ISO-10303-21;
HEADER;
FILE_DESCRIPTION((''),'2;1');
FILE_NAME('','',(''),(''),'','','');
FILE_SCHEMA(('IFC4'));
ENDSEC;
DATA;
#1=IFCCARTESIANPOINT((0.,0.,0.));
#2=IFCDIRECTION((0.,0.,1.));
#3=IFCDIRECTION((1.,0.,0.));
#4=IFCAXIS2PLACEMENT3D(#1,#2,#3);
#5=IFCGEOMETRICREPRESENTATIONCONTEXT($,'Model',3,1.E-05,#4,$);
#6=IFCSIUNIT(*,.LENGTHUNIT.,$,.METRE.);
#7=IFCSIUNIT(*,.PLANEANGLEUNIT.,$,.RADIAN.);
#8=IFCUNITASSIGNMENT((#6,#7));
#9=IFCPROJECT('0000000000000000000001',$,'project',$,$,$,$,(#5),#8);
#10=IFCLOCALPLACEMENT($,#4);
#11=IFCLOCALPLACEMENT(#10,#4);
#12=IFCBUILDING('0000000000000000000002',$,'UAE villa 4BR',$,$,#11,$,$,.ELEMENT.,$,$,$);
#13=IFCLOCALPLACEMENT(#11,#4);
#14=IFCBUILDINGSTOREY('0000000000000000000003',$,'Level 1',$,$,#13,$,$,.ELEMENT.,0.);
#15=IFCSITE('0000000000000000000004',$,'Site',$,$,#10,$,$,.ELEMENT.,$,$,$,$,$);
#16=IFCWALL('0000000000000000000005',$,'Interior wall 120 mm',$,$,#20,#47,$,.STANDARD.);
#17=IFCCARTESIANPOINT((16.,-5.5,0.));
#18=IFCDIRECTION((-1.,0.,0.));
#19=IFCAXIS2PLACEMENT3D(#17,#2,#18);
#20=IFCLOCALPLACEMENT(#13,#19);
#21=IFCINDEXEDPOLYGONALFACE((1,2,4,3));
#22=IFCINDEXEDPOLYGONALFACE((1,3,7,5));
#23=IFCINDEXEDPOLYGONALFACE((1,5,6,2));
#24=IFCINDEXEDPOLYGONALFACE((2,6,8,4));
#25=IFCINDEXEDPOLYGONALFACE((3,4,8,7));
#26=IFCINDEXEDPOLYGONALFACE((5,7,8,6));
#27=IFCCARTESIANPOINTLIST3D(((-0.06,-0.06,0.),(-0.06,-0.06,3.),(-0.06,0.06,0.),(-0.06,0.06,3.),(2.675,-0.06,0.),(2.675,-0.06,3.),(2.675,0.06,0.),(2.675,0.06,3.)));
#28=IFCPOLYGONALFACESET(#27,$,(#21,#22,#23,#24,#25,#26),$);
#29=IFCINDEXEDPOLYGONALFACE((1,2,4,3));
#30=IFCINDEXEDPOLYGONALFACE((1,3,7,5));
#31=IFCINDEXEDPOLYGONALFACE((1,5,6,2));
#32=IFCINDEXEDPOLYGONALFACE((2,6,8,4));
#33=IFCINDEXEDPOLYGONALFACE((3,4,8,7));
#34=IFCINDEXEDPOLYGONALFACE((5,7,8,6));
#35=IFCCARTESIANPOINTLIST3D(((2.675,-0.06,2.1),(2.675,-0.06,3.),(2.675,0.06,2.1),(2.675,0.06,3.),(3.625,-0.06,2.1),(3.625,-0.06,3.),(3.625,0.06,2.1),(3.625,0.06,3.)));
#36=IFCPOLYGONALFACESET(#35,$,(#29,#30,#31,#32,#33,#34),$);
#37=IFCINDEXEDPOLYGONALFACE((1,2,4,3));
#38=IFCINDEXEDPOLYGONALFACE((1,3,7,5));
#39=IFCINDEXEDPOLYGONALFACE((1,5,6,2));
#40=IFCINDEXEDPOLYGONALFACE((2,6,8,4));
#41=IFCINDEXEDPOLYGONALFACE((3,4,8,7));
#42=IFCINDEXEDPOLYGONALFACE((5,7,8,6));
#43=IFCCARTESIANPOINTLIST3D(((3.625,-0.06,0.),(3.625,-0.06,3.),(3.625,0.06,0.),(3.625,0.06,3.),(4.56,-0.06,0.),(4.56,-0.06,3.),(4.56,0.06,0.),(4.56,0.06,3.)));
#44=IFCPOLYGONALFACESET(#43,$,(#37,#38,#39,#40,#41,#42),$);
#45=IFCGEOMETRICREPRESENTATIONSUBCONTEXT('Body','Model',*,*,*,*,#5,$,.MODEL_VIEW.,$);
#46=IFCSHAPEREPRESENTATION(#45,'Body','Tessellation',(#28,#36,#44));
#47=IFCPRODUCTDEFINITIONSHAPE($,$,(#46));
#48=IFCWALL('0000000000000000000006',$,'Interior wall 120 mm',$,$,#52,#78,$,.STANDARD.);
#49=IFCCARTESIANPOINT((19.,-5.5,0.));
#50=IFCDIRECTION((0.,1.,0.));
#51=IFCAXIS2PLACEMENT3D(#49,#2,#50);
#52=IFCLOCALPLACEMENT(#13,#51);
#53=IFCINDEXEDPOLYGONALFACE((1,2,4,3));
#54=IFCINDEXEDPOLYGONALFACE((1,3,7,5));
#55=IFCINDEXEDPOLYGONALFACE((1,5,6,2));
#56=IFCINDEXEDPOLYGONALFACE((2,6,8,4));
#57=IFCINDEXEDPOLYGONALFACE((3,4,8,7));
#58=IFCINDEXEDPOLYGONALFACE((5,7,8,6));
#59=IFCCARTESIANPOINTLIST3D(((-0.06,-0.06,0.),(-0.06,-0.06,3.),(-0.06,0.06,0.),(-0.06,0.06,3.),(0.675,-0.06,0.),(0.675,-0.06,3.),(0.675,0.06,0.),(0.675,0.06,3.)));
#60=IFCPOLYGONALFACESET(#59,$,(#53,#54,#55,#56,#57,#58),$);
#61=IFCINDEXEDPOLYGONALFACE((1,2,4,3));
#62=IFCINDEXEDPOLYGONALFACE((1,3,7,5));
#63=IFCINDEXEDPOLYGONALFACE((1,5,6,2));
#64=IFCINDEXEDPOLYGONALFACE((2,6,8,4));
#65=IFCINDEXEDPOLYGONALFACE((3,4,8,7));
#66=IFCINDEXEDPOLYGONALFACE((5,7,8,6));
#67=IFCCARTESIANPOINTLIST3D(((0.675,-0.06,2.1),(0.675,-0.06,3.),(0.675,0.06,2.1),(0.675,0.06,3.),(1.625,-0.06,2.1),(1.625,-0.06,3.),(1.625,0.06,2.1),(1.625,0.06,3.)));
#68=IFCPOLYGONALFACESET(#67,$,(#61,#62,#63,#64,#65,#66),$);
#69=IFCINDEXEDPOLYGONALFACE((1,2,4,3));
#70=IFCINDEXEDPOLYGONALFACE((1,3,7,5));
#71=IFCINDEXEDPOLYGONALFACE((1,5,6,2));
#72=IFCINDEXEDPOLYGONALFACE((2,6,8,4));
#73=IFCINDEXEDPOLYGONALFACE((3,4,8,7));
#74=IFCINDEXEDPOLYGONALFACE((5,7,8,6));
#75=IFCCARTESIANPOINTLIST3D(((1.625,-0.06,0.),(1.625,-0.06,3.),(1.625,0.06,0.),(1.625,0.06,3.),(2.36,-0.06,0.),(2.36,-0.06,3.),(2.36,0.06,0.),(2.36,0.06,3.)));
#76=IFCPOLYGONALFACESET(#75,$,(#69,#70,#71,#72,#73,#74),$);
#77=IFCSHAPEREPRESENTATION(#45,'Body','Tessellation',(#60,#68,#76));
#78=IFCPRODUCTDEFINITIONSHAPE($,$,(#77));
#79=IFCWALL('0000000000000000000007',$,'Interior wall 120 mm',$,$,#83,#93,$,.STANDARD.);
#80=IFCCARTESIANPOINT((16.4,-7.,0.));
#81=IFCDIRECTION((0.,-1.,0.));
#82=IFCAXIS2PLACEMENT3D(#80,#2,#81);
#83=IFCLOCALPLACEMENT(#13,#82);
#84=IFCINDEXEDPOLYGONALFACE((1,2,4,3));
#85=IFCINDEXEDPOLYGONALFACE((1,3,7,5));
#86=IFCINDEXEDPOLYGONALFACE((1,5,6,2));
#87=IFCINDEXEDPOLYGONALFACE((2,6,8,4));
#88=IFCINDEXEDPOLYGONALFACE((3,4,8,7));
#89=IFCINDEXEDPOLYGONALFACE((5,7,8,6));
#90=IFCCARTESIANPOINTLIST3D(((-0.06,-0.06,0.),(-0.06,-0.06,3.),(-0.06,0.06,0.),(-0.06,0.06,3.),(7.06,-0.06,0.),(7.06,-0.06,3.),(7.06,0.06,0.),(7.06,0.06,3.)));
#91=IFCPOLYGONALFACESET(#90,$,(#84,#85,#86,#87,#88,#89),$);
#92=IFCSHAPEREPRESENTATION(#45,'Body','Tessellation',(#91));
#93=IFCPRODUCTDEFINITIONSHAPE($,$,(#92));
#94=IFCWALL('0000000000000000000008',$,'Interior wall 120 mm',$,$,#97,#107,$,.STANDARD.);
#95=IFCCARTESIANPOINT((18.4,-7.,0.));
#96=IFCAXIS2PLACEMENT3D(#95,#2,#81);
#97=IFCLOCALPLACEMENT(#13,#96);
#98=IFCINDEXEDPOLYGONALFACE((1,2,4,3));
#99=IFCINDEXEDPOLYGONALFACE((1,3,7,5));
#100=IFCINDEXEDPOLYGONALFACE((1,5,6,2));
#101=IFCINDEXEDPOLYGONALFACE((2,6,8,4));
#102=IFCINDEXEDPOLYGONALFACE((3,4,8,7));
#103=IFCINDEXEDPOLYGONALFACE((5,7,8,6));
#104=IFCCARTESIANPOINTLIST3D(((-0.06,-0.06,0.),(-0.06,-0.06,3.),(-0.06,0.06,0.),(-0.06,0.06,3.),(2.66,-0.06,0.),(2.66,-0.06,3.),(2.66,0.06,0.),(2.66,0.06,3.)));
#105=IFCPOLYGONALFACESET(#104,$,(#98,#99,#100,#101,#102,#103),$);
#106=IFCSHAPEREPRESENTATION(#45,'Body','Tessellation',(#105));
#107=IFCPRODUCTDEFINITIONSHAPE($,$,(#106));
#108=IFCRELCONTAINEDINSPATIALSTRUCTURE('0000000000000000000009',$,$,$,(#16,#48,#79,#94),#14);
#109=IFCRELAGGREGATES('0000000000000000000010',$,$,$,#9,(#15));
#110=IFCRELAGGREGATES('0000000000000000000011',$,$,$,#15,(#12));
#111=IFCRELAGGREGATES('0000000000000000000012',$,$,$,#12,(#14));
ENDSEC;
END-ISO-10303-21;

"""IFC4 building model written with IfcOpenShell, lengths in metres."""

from ifc_helpers import new_model, si_unit, frame, origin_with_axes, origin_2d, place, context, subcontext, project, spatial, rectangle, extrude, element, save


model = new_model("IFC4")

# Units and contexts
model_context = context("Model", 3, precision=1e-05, world=origin_with_axes())
body_context = subcontext(model_context, "Body", "Model", "MODEL_VIEW")
ifc_project = project(units=[si_unit("LENGTHUNIT", "METRE"), si_unit("PLANEANGLEUNIT", "RADIAN")], contexts=[model_context])

# Site, building, storey
site_placement = place(None, origin_with_axes())
site = spatial("IfcSite", under=ifc_project, at=site_placement, Name="Site", CompositionType="ELEMENT")
building_placement = place(site_placement, origin_with_axes())
building = spatial("IfcBuilding", under=site, at=building_placement, Name="UAE villa 4BR", CompositionType="ELEMENT")
storey_placement = place(building_placement, origin_with_axes())
storey = spatial("IfcBuildingStorey", under=building, at=storey_placement, Name="Level 1", CompositionType="ELEMENT", Elevation=0.0)

# Walls
wall_1_placement = place(storey_placement, frame((16.0, -5.5, 0.0), z_axis=(0.0, 0.0, 1.0), x_axis=(-1.0, 0.0, 0.0)))
element("IfcWall", 1, at=wall_1_placement, inside=storey, Name="Interior wall 120 mm", PredefinedType="STANDARD", context=body_context, shape_type="SweptSolid", body=[
    extrude(rectangle(XDim=2.735, YDim=0.12, at=origin_2d()), frame((1.3075, 0.0, 0.0)), (0.0, 0.0, 1.0), 3.0),
    extrude(rectangle(XDim=0.95, YDim=0.12, at=origin_2d()), frame((3.15, 0.0, 2.1)), (0.0, 0.0, 1.0), 0.9),
    extrude(rectangle(XDim=0.935, YDim=0.12, at=origin_2d()), frame((4.0925, 0.0, 0.0)), (0.0, 0.0, 1.0), 3.0),
])
wall_2_placement = place(storey_placement, frame((19.0, -5.5, 0.0), z_axis=(0.0, 0.0, 1.0), x_axis=(0.0, 1.0, 0.0)))
element("IfcWall", 2, at=wall_2_placement, inside=storey, Name="Interior wall 120 mm", PredefinedType="STANDARD", context=body_context, shape_type="SweptSolid", body=[
    extrude(rectangle(XDim=0.735, YDim=0.12, at=origin_2d()), frame((0.3075, 0.0, 0.0)), (0.0, 0.0, 1.0), 3.0),
    extrude(rectangle(XDim=0.95, YDim=0.12, at=origin_2d()), frame((1.15, 0.0, 2.1)), (0.0, 0.0, 1.0), 0.9),
    extrude(rectangle(XDim=0.735, YDim=0.12, at=origin_2d()), frame((1.9925, 0.0, 0.0)), (0.0, 0.0, 1.0), 3.0),
])
wall_3_placement = place(storey_placement, frame((16.4, -7.0, 0.0), z_axis=(0.0, 0.0, 1.0), x_axis=(0.0, -1.0, 0.0)))
element("IfcWall", 3, at=wall_3_placement, inside=storey, Name="Interior wall 120 mm", PredefinedType="STANDARD", context=body_context, shape_type="SweptSolid", body=[
    extrude(rectangle(XDim=7.12, YDim=0.12, at=origin_2d()), frame((3.5, 0.0, 0.0)), (0.0, 0.0, 1.0), 3.0),
])
wall_4_placement = place(storey_placement, frame((18.4, -7.0, 0.0), z_axis=(0.0, 0.0, 1.0), x_axis=(0.0, -1.0, 0.0)))
element("IfcWall", 4, at=wall_4_placement, inside=storey, Name="Interior wall 120 mm", PredefinedType="STANDARD", context=body_context, shape_type="SweptSolid", body=[
    extrude(rectangle(XDim=2.72, YDim=0.12, at=origin_2d()), frame((1.3, 0.0, 0.0)), (0.0, 0.0, 1.0), 3.0),
])

save(model, "model.ifc")
